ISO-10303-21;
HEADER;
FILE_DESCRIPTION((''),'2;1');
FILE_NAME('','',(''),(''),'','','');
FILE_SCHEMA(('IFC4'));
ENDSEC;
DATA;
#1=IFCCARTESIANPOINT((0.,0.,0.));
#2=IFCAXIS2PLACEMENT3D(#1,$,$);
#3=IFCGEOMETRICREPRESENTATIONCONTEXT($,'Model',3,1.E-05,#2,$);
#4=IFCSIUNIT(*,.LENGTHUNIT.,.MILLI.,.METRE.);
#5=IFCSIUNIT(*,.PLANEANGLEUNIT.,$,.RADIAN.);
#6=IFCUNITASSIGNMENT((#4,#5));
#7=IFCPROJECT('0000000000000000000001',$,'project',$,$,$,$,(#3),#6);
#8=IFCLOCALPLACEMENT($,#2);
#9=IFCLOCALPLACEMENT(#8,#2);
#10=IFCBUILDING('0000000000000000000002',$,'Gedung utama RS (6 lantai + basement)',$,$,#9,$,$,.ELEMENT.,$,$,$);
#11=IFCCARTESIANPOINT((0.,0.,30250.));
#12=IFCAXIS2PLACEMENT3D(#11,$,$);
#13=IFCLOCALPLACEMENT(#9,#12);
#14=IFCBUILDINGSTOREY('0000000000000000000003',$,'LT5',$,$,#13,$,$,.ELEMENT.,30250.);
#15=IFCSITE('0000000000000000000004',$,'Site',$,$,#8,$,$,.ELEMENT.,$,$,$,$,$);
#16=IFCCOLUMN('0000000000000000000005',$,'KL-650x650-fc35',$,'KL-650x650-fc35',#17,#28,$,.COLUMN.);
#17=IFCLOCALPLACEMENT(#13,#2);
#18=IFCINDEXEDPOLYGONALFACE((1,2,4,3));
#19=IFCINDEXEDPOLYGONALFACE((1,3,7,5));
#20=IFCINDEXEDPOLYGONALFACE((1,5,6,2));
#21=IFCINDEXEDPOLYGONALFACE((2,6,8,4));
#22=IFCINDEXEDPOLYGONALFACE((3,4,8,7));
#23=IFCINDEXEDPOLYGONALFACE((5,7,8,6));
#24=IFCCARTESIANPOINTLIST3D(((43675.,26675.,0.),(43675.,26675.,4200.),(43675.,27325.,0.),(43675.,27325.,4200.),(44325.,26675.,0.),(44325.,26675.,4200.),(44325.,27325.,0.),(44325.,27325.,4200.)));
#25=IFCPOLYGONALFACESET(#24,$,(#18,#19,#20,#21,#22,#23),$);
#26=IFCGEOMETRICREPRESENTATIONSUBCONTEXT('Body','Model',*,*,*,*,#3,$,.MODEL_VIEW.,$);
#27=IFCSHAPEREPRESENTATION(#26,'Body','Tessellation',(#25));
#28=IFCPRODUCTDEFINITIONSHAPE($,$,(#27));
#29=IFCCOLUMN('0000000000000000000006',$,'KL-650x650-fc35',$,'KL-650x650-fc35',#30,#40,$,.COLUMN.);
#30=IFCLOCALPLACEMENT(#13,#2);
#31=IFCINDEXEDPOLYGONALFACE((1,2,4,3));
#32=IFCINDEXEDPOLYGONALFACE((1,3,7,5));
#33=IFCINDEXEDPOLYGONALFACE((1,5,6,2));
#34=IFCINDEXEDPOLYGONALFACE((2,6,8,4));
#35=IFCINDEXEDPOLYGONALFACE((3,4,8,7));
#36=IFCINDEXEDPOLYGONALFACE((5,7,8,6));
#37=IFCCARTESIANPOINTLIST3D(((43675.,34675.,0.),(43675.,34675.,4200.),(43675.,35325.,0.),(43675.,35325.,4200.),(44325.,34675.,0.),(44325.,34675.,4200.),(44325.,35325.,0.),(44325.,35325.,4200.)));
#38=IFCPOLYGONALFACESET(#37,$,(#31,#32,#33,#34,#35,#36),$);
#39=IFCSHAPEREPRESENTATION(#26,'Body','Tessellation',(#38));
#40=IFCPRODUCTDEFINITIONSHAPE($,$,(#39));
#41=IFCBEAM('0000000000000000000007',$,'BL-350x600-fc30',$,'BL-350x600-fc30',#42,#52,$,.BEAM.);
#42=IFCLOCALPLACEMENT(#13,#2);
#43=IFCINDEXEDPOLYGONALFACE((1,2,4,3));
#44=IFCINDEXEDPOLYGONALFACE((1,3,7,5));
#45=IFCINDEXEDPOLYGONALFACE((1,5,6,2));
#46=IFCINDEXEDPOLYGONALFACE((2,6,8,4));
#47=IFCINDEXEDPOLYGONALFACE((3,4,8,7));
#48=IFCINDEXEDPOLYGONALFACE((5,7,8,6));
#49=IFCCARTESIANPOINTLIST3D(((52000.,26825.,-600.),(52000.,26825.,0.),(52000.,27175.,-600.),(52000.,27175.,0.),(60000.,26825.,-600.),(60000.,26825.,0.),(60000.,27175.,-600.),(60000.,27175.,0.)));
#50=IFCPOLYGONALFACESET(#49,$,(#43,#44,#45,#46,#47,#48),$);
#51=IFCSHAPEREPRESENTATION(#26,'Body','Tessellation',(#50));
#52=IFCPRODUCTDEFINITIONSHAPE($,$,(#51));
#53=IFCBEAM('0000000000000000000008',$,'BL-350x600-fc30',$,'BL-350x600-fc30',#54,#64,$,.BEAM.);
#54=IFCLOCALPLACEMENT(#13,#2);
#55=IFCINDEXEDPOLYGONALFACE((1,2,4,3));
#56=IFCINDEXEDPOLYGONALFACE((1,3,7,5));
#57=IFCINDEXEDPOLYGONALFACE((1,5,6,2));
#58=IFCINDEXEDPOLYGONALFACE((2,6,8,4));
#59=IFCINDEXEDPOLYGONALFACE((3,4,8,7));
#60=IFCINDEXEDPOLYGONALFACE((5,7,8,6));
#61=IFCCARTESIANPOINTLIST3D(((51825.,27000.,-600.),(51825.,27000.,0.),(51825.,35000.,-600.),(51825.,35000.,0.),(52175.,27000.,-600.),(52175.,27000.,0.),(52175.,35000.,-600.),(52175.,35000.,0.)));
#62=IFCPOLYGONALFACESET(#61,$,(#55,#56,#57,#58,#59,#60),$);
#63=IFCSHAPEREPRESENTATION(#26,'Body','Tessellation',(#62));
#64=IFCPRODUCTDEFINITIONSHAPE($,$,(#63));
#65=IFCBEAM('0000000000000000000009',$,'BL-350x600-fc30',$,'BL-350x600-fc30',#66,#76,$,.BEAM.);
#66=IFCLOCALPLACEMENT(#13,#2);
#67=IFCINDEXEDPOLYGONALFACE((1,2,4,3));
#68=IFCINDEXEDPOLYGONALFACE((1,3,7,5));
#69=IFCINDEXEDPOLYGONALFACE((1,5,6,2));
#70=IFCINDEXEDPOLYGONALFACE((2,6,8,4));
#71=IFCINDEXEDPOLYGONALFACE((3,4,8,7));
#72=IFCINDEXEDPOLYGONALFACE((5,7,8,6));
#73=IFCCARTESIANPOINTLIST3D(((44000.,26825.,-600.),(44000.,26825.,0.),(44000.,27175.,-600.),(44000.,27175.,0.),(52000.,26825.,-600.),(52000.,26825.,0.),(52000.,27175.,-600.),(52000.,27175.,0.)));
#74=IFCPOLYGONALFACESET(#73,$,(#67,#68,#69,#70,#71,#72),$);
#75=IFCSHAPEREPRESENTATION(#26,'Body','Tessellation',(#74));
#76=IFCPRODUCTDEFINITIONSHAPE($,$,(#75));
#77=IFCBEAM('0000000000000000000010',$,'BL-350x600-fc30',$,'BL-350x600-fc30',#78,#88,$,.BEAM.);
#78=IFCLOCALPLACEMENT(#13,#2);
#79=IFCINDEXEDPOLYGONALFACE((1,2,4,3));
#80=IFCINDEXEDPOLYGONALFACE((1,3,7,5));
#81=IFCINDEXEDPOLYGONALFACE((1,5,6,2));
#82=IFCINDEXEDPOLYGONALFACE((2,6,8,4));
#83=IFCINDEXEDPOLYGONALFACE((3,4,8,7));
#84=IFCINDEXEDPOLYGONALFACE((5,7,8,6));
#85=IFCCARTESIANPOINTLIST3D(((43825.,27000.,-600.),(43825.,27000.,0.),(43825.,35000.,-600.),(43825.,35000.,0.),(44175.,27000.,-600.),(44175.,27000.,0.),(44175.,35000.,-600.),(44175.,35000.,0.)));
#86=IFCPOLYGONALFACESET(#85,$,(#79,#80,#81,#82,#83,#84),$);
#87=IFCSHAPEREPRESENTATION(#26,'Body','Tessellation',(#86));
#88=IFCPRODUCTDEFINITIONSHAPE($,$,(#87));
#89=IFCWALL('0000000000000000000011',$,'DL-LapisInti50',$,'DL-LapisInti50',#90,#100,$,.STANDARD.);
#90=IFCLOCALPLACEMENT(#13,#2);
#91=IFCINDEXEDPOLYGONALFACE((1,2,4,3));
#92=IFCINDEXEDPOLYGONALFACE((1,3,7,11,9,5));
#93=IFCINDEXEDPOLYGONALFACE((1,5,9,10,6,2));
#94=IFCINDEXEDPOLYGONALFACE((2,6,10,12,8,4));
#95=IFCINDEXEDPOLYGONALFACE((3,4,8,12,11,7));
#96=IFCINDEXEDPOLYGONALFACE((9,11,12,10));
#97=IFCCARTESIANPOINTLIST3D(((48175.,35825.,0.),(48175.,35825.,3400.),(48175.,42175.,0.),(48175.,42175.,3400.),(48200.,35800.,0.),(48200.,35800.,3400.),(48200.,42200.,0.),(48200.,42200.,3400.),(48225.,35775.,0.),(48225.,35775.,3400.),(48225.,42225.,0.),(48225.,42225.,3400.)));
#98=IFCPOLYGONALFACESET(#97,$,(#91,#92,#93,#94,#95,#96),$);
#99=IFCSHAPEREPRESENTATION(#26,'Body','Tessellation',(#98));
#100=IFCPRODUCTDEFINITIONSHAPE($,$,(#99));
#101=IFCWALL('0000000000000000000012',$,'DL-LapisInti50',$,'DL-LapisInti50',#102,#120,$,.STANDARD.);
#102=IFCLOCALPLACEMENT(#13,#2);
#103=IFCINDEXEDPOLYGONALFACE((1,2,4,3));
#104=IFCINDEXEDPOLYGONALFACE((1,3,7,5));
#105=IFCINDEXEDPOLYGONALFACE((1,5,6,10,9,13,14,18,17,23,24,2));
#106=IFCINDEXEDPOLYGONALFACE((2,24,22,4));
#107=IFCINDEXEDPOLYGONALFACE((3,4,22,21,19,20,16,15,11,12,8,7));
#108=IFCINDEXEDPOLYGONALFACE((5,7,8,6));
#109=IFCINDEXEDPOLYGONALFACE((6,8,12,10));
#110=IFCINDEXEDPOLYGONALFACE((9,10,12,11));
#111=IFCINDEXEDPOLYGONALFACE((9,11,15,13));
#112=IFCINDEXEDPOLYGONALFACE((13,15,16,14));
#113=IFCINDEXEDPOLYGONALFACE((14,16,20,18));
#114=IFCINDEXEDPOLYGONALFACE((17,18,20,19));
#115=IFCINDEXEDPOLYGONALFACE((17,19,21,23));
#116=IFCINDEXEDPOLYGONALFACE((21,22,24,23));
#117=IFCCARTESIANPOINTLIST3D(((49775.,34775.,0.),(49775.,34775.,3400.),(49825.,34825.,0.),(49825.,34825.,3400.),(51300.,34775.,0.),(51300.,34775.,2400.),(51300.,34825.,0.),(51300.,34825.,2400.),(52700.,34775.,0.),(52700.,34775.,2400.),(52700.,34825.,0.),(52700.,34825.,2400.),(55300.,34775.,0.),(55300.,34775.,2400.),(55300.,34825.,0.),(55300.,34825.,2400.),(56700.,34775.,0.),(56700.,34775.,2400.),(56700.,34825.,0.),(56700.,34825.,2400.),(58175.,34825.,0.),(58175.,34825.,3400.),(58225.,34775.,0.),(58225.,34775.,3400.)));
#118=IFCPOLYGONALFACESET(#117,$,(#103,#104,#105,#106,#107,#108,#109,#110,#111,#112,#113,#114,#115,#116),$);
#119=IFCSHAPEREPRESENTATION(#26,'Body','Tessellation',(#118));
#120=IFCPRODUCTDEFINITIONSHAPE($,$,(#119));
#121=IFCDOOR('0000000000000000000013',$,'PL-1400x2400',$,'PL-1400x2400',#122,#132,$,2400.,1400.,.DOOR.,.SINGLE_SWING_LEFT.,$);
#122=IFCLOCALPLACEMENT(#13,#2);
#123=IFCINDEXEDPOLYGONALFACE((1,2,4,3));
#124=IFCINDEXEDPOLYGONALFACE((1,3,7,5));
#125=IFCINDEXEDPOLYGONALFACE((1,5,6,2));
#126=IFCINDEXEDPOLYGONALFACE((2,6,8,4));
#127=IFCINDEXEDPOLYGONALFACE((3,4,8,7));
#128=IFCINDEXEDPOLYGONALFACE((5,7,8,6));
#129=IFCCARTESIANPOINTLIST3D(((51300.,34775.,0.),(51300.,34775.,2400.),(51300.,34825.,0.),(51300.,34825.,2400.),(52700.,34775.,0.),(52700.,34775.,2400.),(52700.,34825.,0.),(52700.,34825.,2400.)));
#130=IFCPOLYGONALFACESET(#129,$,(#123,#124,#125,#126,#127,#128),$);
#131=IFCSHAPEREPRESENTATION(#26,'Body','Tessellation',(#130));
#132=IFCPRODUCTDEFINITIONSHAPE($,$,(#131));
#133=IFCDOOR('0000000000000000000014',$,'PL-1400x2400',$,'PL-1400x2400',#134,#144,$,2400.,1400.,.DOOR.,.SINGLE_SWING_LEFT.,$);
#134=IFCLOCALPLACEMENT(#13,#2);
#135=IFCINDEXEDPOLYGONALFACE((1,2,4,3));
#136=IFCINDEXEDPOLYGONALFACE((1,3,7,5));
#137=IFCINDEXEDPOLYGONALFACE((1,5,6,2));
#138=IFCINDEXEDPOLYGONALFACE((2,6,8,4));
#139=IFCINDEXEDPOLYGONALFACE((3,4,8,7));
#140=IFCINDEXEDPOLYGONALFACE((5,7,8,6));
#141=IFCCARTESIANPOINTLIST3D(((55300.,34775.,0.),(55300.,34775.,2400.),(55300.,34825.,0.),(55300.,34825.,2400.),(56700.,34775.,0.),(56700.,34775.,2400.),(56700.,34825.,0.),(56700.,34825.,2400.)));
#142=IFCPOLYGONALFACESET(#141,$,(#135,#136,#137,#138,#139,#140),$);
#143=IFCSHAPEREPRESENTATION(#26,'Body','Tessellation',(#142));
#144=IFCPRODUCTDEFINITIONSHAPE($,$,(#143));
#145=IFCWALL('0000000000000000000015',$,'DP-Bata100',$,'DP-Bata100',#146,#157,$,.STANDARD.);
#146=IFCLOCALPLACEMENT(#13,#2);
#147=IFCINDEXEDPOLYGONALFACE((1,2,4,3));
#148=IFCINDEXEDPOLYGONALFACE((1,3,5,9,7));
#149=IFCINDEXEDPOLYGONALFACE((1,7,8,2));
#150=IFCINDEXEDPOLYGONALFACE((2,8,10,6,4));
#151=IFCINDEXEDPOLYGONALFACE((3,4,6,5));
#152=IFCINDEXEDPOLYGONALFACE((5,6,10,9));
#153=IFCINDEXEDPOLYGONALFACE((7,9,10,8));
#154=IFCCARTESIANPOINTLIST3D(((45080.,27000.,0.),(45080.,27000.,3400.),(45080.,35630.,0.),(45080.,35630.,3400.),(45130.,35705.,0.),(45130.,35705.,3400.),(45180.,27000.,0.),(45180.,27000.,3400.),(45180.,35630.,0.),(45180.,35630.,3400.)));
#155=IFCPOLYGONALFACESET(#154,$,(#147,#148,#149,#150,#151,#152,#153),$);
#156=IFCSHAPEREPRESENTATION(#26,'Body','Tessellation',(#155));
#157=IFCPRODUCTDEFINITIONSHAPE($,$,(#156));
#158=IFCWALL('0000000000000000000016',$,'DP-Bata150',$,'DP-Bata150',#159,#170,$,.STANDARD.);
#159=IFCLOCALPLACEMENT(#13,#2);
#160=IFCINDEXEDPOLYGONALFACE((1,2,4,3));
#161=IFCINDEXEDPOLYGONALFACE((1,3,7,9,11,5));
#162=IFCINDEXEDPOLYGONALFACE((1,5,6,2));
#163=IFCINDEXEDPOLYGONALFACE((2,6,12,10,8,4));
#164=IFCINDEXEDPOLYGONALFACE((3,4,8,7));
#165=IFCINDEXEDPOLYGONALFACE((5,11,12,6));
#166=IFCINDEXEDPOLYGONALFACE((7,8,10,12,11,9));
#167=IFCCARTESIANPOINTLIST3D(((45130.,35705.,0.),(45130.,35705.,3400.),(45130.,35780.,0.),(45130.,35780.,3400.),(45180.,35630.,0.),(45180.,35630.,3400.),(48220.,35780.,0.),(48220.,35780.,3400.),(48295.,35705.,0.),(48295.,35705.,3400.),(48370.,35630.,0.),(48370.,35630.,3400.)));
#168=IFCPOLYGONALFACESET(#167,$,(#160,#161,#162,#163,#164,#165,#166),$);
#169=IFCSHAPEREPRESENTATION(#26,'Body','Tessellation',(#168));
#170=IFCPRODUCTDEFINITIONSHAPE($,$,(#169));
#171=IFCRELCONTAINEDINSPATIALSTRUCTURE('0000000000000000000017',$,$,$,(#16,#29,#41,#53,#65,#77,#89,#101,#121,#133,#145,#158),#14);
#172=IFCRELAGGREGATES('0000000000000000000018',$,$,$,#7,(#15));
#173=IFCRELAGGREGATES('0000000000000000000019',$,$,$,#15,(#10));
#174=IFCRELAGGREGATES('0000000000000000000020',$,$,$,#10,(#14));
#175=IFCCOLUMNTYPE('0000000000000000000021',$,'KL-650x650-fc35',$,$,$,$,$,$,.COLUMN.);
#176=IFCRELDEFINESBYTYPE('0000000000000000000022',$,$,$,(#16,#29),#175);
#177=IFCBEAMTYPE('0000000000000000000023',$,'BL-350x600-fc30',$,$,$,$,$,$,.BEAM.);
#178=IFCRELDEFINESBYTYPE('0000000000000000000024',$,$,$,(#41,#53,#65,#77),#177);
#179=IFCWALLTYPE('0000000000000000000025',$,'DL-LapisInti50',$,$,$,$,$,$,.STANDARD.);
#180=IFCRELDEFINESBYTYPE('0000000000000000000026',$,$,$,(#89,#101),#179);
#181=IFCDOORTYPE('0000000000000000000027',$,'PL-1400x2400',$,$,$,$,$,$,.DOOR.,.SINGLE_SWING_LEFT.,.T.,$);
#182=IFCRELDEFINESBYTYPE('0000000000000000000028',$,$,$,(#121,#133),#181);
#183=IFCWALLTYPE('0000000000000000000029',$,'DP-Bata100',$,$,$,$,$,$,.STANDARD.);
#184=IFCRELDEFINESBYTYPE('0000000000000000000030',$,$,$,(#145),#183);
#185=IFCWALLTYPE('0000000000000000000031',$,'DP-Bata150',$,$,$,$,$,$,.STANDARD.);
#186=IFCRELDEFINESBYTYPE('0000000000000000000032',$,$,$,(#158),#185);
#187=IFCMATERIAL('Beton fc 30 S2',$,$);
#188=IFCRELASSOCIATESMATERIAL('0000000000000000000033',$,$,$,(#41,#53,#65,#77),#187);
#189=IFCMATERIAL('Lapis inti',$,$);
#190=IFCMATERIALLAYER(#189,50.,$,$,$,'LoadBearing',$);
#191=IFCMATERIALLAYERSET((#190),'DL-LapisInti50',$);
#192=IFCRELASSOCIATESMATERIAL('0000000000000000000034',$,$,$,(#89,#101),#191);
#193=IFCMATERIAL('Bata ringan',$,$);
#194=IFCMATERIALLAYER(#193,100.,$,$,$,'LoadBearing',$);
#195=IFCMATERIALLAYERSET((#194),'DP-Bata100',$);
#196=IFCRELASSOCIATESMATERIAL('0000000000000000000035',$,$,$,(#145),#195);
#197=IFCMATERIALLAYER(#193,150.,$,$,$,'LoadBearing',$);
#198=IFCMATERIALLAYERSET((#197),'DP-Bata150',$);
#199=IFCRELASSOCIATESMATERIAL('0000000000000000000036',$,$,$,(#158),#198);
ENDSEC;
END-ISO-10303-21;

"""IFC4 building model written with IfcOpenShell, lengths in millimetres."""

from ifc_helpers import new_model, si_unit, frame, frame_2d, origin, origin_2d, place, context, subcontext, project, spatial, polyline, rectangle, outline, extrude, material, layer, layer_set, layer_usage, material_profile, profile_set, profile_usage, type_object, element, fill, save


model = new_model("IFC4")

# Units and contexts
model_context = context("Model", 3, precision=1e-05, world=origin())
body_context = subcontext(model_context, "Body", "Model", "MODEL_VIEW")
ifc_project = project(units=[si_unit("LENGTHUNIT", "METRE", prefix="MILLI"), si_unit("PLANEANGLEUNIT", "RADIAN")], contexts=[model_context])

# Site, building, storey
site_placement = place(None, origin())
site = spatial("IfcSite", under=ifc_project, at=site_placement, Name="Site", CompositionType="ELEMENT")
building_placement = place(site_placement, origin())
building = spatial("IfcBuilding", under=site, at=building_placement, Name="Gedung utama RS (6 lantai + basement)", CompositionType="ELEMENT")
storey_placement = place(building_placement, frame((0.0, 0.0, 30250.0)))
storey = spatial("IfcBuildingStorey", under=building, at=storey_placement, Name="LT5", CompositionType="ELEMENT", Elevation=30250.0)

# Columns
ifc_material_profile_1 = material_profile(None, rectangle(XDim=650.0, YDim=650.0, at=origin_2d()), Name="KL-650x650-fc35")
ifc_profile_set_1 = profile_set([ifc_material_profile_1], Name="KL-650x650-fc35")
ifc_profile_usage_1 = profile_usage(ifc_profile_set_1, cardinal=5)
column_type = type_object("IfcColumnType", Name="KL-650x650-fc35", PredefinedType="COLUMN")
for number, where, z_axis, x_axis, name in (
    (1, (44000.0, 27000.0, 0.0), (0.0, 0.0, 1.0), (1.0, 0.0, 0.0), "KL-650x650-fc35"),
    (2, (44000.0, 35000.0, 0.0), (0.0, 0.0, 1.0), (1.0, 0.0, 0.0), "KL-650x650-fc35"),
):
    element("IfcColumn", number, at=place(storey_placement, frame(where, z_axis=z_axis, x_axis=x_axis)), inside=storey, type_object=column_type, material=ifc_profile_usage_1, Name=name, ObjectType="KL-650x650-fc35", PredefinedType="COLUMN", context=body_context, shape_type="SweptSolid", body=[
        extrude(rectangle(XDim=650.0, YDim=650.0, at=origin_2d()), origin(), (0.0, 0.0, 1.0), 4200.0),
    ])

# Beams
ifc_material_1 = material(Name="Beton fc 30 S2")
ifc_material_profile_2 = material_profile(ifc_material_1, rectangle(XDim=350.0, YDim=600.0, at=origin_2d()), Name="BL-350x600-fc30")
ifc_profile_set_2 = profile_set([ifc_material_profile_2], Name="BL-350x600-fc30")
ifc_profile_usage_2 = profile_usage(ifc_profile_set_2, cardinal=8)
beam_type = type_object("IfcBeamType", Name="BL-350x600-fc30", PredefinedType="BEAM")
beam_1_placement = place(storey_placement, frame((52000.0, 27000.0, -300.0)))
element("IfcBeam", 3, at=beam_1_placement, inside=storey, type_object=beam_type, material=ifc_profile_usage_2, Name="BL-350x600-fc30", ObjectType="BL-350x600-fc30", PredefinedType="BEAM", context=body_context, shape_type="SweptSolid", body=[
    extrude(rectangle(XDim=350.0, YDim=600.0, at=origin_2d()), frame((0.0, 0.0, 0.0), z_axis=(1.0, 0.0, 0.0), x_axis=(0.0, 1.0, 0.0)), (0.0, 0.0, 1.0), 8000.0),
])
beam_2_placement = place(storey_placement, frame((52000.0, 27000.0, -300.0)))
element("IfcBeam", 4, at=beam_2_placement, inside=storey, type_object=beam_type, material=ifc_profile_usage_2, Name="BL-350x600-fc30", ObjectType="BL-350x600-fc30", PredefinedType="BEAM", context=body_context, shape_type="SweptSolid", body=[
    extrude(rectangle(XDim=350.0, YDim=600.0, at=origin_2d()), frame((0.0, 0.0, 0.0), z_axis=(0.0, 1.0, 0.0), x_axis=(-1.0, 0.0, 0.0)), (0.0, 0.0, 1.0), 8000.0),
])
beam_3_placement = place(storey_placement, frame((44000.0, 27000.0, -300.0)))
element("IfcBeam", 5, at=beam_3_placement, inside=storey, type_object=beam_type, material=ifc_profile_usage_2, Name="BL-350x600-fc30", ObjectType="BL-350x600-fc30", PredefinedType="BEAM", context=body_context, shape_type="SweptSolid", body=[
    extrude(rectangle(XDim=350.0, YDim=600.0, at=origin_2d()), frame((0.0, 0.0, 0.0), z_axis=(1.0, 0.0, 0.0), x_axis=(0.0, 1.0, 0.0)), (0.0, 0.0, 1.0), 8000.0),
])
beam_4_placement = place(storey_placement, frame((44000.0, 27000.0, -300.0)))
element("IfcBeam", 6, at=beam_4_placement, inside=storey, type_object=beam_type, material=ifc_profile_usage_2, Name="BL-350x600-fc30", ObjectType="BL-350x600-fc30", PredefinedType="BEAM", context=body_context, shape_type="SweptSolid", body=[
    extrude(rectangle(XDim=350.0, YDim=600.0, at=origin_2d()), frame((0.0, 0.0, 0.0), z_axis=(0.0, 1.0, 0.0), x_axis=(-1.0, 0.0, 0.0)), (0.0, 0.0, 1.0), 8000.0),
])

# Wall
ifc_material_2 = material(Name="Lapis inti")
ifc_layer_1 = layer(ifc_material_2, 50.0, Category="LoadBearing")
ifc_layer_set_1 = layer_set([ifc_layer_1], Name="DL-LapisInti50")
ifc_layer_usage_1 = layer_usage(ifc_layer_set_1, "AXIS2", "NEGATIVE", 25.0)
wall_type_1 = type_object("IfcWallType", Name="DL-LapisInti50", PredefinedType="STANDARD")
wall_1_placement = place(storey_placement, frame((48200.0, 35800.0, 0.0), z_axis=(0.0, 0.0, 1.0), x_axis=(0.0, 1.0, 0.0)))
element("IfcWall", 7, at=wall_1_placement, inside=storey, type_object=wall_type_1, material=ifc_layer_usage_1, Name="DL-LapisInti50", ObjectType="DL-LapisInti50", PredefinedType="STANDARD", context=body_context, shape_type="SweptSolid", body=[
    extrude(outline(polyline([(-25.0, -25.0), (0.0, 0.0), (25.0, 25.0), (6375.0, 25.0), (6400.0, 0.0), (6425.0, -25.0), (-25.0, -25.0)])), origin(), (0.0, 0.0, 1.0), 3400.0),
])

# Wall, openings, doors
wall_2_placement = place(storey_placement, frame((49800.0, 34800.0, 0.0), z_axis=(0.0, 0.0, 1.0), x_axis=(1.0, 0.0, 0.0)))
wall_2 = element("IfcWall", 8, at=wall_2_placement, inside=storey, type_object=wall_type_1, material=ifc_layer_usage_1, Name="DL-LapisInti50", ObjectType="DL-LapisInti50", PredefinedType="STANDARD", context=body_context, shape_type="SweptSolid", body=[
    extrude(outline(polyline([(-25.0, -25.0), (0.0, 0.0), (25.0, 25.0), (8375.0, 25.0), (8400.0, 0.0), (8425.0, -25.0), (-25.0, -25.0)])), origin(), (0.0, 0.0, 1.0), 3400.0),
])
opening_1_placement = place(wall_2_placement, frame((1500.0, 0.0, 0.0), z_axis=(0.0, 0.0, 1.0), x_axis=(1.0, 0.0, 0.0)))
opening_1 = element("IfcOpeningElement", 9, at=opening_1_placement, cuts=wall_2, PredefinedType="OPENING", context=body_context, shape_type="SweptSolid", body=[
    extrude(rectangle(XDim=1400.0, YDim=70.0, at=frame_2d((700.0, 0.0))), origin(), (0.0, 0.0, 1.0), 2400.0),
])
opening_2_placement = place(wall_2_placement, frame((5500.0, 0.0, 0.0), z_axis=(0.0, 0.0, 1.0), x_axis=(1.0, 0.0, 0.0)))
opening_2 = element("IfcOpeningElement", 10, at=opening_2_placement, cuts=wall_2, PredefinedType="OPENING", context=body_context, shape_type="SweptSolid", body=[
    extrude(rectangle(XDim=1400.0, YDim=70.0, at=frame_2d((700.0, 0.0))), origin(), (0.0, 0.0, 1.0), 2400.0),
])
door_type = type_object("IfcDoorType", Name="PL-1400x2400", OperationType="SINGLE_SWING_LEFT", ParameterTakesPrecedence=True, PredefinedType="DOOR")
door_1_placement = place(opening_1_placement, origin())
door_1 = element("IfcDoor", 11, at=door_1_placement, inside=storey, type_object=door_type, Name="PL-1400x2400", ObjectType="PL-1400x2400", OperationType="SINGLE_SWING_LEFT", OverallHeight=2400.0, OverallWidth=1400.0, PredefinedType="DOOR", context=body_context, shape_type="SweptSolid", body=[
    extrude(rectangle(XDim=1400.0, YDim=50.0, at=frame_2d((700.0, 0.0))), origin(), (0.0, 0.0, 1.0), 2400.0),
])
fill(opening_1, door_1)
door_2_placement = place(opening_2_placement, origin())
door_2 = element("IfcDoor", 12, at=door_2_placement, inside=storey, type_object=door_type, Name="PL-1400x2400", ObjectType="PL-1400x2400", OperationType="SINGLE_SWING_LEFT", OverallHeight=2400.0, OverallWidth=1400.0, PredefinedType="DOOR", context=body_context, shape_type="SweptSolid", body=[
    extrude(rectangle(XDim=1400.0, YDim=50.0, at=frame_2d((700.0, 0.0))), origin(), (0.0, 0.0, 1.0), 2400.0),
])
fill(opening_2, door_2)

# Walls
ifc_material_3 = material(Name="Bata ringan")
ifc_layer_2 = layer(ifc_material_3, 100.0, Category="LoadBearing")
ifc_layer_set_2 = layer_set([ifc_layer_2], Name="DP-Bata100")
ifc_layer_usage_2 = layer_usage(ifc_layer_set_2, "AXIS2", "NEGATIVE", 50.0)
wall_type_2 = type_object("IfcWallType", Name="DP-Bata100", PredefinedType="STANDARD")
wall_3_placement = place(storey_placement, frame((45130.0, 35705.0, 0.0), z_axis=(0.0, 0.0, 1.0), x_axis=(0.0, -1.0, 0.0)))
element("IfcWall", 13, at=wall_3_placement, inside=storey, type_object=wall_type_2, material=ifc_layer_usage_2, Name="DP-Bata100", ObjectType="DP-Bata100", PredefinedType="STANDARD", context=body_context, shape_type="SweptSolid", body=[
    extrude(outline(polyline([(75.0, -50.0), (0.0, 0.0), (75.0, 50.0), (8705.0, 50.0), (8705.0, -50.0), (75.0, -50.0)])), origin(), (0.0, 0.0, 1.0), 3400.0),
])
ifc_layer_3 = layer(ifc_material_3, 150.0, Category="LoadBearing")
ifc_layer_set_3 = layer_set([ifc_layer_3], Name="DP-Bata150")
ifc_layer_usage_3 = layer_usage(ifc_layer_set_3, "AXIS2", "NEGATIVE", 75.0)
wall_type_3 = type_object("IfcWallType", Name="DP-Bata150", PredefinedType="STANDARD")
wall_4_placement = place(storey_placement, frame((45130.0, 35705.0, 0.0), z_axis=(0.0, 0.0, 1.0), x_axis=(1.0, 0.0, 0.0)))
element("IfcWall", 14, at=wall_4_placement, inside=storey, type_object=wall_type_3, material=ifc_layer_usage_3, Name="DP-Bata150", ObjectType="DP-Bata150", PredefinedType="STANDARD", context=body_context, shape_type="SweptSolid", body=[
    extrude(outline(polyline([(50.0, -75.0), (0.0, 0.0), (0.0, 75.0), (3090.0, 75.0), (3165.0, 0.0), (3240.0, -75.0), (50.0, -75.0)])), origin(), (0.0, 0.0, 1.0), 3400.0),
])

save(model, "model.ifc")
